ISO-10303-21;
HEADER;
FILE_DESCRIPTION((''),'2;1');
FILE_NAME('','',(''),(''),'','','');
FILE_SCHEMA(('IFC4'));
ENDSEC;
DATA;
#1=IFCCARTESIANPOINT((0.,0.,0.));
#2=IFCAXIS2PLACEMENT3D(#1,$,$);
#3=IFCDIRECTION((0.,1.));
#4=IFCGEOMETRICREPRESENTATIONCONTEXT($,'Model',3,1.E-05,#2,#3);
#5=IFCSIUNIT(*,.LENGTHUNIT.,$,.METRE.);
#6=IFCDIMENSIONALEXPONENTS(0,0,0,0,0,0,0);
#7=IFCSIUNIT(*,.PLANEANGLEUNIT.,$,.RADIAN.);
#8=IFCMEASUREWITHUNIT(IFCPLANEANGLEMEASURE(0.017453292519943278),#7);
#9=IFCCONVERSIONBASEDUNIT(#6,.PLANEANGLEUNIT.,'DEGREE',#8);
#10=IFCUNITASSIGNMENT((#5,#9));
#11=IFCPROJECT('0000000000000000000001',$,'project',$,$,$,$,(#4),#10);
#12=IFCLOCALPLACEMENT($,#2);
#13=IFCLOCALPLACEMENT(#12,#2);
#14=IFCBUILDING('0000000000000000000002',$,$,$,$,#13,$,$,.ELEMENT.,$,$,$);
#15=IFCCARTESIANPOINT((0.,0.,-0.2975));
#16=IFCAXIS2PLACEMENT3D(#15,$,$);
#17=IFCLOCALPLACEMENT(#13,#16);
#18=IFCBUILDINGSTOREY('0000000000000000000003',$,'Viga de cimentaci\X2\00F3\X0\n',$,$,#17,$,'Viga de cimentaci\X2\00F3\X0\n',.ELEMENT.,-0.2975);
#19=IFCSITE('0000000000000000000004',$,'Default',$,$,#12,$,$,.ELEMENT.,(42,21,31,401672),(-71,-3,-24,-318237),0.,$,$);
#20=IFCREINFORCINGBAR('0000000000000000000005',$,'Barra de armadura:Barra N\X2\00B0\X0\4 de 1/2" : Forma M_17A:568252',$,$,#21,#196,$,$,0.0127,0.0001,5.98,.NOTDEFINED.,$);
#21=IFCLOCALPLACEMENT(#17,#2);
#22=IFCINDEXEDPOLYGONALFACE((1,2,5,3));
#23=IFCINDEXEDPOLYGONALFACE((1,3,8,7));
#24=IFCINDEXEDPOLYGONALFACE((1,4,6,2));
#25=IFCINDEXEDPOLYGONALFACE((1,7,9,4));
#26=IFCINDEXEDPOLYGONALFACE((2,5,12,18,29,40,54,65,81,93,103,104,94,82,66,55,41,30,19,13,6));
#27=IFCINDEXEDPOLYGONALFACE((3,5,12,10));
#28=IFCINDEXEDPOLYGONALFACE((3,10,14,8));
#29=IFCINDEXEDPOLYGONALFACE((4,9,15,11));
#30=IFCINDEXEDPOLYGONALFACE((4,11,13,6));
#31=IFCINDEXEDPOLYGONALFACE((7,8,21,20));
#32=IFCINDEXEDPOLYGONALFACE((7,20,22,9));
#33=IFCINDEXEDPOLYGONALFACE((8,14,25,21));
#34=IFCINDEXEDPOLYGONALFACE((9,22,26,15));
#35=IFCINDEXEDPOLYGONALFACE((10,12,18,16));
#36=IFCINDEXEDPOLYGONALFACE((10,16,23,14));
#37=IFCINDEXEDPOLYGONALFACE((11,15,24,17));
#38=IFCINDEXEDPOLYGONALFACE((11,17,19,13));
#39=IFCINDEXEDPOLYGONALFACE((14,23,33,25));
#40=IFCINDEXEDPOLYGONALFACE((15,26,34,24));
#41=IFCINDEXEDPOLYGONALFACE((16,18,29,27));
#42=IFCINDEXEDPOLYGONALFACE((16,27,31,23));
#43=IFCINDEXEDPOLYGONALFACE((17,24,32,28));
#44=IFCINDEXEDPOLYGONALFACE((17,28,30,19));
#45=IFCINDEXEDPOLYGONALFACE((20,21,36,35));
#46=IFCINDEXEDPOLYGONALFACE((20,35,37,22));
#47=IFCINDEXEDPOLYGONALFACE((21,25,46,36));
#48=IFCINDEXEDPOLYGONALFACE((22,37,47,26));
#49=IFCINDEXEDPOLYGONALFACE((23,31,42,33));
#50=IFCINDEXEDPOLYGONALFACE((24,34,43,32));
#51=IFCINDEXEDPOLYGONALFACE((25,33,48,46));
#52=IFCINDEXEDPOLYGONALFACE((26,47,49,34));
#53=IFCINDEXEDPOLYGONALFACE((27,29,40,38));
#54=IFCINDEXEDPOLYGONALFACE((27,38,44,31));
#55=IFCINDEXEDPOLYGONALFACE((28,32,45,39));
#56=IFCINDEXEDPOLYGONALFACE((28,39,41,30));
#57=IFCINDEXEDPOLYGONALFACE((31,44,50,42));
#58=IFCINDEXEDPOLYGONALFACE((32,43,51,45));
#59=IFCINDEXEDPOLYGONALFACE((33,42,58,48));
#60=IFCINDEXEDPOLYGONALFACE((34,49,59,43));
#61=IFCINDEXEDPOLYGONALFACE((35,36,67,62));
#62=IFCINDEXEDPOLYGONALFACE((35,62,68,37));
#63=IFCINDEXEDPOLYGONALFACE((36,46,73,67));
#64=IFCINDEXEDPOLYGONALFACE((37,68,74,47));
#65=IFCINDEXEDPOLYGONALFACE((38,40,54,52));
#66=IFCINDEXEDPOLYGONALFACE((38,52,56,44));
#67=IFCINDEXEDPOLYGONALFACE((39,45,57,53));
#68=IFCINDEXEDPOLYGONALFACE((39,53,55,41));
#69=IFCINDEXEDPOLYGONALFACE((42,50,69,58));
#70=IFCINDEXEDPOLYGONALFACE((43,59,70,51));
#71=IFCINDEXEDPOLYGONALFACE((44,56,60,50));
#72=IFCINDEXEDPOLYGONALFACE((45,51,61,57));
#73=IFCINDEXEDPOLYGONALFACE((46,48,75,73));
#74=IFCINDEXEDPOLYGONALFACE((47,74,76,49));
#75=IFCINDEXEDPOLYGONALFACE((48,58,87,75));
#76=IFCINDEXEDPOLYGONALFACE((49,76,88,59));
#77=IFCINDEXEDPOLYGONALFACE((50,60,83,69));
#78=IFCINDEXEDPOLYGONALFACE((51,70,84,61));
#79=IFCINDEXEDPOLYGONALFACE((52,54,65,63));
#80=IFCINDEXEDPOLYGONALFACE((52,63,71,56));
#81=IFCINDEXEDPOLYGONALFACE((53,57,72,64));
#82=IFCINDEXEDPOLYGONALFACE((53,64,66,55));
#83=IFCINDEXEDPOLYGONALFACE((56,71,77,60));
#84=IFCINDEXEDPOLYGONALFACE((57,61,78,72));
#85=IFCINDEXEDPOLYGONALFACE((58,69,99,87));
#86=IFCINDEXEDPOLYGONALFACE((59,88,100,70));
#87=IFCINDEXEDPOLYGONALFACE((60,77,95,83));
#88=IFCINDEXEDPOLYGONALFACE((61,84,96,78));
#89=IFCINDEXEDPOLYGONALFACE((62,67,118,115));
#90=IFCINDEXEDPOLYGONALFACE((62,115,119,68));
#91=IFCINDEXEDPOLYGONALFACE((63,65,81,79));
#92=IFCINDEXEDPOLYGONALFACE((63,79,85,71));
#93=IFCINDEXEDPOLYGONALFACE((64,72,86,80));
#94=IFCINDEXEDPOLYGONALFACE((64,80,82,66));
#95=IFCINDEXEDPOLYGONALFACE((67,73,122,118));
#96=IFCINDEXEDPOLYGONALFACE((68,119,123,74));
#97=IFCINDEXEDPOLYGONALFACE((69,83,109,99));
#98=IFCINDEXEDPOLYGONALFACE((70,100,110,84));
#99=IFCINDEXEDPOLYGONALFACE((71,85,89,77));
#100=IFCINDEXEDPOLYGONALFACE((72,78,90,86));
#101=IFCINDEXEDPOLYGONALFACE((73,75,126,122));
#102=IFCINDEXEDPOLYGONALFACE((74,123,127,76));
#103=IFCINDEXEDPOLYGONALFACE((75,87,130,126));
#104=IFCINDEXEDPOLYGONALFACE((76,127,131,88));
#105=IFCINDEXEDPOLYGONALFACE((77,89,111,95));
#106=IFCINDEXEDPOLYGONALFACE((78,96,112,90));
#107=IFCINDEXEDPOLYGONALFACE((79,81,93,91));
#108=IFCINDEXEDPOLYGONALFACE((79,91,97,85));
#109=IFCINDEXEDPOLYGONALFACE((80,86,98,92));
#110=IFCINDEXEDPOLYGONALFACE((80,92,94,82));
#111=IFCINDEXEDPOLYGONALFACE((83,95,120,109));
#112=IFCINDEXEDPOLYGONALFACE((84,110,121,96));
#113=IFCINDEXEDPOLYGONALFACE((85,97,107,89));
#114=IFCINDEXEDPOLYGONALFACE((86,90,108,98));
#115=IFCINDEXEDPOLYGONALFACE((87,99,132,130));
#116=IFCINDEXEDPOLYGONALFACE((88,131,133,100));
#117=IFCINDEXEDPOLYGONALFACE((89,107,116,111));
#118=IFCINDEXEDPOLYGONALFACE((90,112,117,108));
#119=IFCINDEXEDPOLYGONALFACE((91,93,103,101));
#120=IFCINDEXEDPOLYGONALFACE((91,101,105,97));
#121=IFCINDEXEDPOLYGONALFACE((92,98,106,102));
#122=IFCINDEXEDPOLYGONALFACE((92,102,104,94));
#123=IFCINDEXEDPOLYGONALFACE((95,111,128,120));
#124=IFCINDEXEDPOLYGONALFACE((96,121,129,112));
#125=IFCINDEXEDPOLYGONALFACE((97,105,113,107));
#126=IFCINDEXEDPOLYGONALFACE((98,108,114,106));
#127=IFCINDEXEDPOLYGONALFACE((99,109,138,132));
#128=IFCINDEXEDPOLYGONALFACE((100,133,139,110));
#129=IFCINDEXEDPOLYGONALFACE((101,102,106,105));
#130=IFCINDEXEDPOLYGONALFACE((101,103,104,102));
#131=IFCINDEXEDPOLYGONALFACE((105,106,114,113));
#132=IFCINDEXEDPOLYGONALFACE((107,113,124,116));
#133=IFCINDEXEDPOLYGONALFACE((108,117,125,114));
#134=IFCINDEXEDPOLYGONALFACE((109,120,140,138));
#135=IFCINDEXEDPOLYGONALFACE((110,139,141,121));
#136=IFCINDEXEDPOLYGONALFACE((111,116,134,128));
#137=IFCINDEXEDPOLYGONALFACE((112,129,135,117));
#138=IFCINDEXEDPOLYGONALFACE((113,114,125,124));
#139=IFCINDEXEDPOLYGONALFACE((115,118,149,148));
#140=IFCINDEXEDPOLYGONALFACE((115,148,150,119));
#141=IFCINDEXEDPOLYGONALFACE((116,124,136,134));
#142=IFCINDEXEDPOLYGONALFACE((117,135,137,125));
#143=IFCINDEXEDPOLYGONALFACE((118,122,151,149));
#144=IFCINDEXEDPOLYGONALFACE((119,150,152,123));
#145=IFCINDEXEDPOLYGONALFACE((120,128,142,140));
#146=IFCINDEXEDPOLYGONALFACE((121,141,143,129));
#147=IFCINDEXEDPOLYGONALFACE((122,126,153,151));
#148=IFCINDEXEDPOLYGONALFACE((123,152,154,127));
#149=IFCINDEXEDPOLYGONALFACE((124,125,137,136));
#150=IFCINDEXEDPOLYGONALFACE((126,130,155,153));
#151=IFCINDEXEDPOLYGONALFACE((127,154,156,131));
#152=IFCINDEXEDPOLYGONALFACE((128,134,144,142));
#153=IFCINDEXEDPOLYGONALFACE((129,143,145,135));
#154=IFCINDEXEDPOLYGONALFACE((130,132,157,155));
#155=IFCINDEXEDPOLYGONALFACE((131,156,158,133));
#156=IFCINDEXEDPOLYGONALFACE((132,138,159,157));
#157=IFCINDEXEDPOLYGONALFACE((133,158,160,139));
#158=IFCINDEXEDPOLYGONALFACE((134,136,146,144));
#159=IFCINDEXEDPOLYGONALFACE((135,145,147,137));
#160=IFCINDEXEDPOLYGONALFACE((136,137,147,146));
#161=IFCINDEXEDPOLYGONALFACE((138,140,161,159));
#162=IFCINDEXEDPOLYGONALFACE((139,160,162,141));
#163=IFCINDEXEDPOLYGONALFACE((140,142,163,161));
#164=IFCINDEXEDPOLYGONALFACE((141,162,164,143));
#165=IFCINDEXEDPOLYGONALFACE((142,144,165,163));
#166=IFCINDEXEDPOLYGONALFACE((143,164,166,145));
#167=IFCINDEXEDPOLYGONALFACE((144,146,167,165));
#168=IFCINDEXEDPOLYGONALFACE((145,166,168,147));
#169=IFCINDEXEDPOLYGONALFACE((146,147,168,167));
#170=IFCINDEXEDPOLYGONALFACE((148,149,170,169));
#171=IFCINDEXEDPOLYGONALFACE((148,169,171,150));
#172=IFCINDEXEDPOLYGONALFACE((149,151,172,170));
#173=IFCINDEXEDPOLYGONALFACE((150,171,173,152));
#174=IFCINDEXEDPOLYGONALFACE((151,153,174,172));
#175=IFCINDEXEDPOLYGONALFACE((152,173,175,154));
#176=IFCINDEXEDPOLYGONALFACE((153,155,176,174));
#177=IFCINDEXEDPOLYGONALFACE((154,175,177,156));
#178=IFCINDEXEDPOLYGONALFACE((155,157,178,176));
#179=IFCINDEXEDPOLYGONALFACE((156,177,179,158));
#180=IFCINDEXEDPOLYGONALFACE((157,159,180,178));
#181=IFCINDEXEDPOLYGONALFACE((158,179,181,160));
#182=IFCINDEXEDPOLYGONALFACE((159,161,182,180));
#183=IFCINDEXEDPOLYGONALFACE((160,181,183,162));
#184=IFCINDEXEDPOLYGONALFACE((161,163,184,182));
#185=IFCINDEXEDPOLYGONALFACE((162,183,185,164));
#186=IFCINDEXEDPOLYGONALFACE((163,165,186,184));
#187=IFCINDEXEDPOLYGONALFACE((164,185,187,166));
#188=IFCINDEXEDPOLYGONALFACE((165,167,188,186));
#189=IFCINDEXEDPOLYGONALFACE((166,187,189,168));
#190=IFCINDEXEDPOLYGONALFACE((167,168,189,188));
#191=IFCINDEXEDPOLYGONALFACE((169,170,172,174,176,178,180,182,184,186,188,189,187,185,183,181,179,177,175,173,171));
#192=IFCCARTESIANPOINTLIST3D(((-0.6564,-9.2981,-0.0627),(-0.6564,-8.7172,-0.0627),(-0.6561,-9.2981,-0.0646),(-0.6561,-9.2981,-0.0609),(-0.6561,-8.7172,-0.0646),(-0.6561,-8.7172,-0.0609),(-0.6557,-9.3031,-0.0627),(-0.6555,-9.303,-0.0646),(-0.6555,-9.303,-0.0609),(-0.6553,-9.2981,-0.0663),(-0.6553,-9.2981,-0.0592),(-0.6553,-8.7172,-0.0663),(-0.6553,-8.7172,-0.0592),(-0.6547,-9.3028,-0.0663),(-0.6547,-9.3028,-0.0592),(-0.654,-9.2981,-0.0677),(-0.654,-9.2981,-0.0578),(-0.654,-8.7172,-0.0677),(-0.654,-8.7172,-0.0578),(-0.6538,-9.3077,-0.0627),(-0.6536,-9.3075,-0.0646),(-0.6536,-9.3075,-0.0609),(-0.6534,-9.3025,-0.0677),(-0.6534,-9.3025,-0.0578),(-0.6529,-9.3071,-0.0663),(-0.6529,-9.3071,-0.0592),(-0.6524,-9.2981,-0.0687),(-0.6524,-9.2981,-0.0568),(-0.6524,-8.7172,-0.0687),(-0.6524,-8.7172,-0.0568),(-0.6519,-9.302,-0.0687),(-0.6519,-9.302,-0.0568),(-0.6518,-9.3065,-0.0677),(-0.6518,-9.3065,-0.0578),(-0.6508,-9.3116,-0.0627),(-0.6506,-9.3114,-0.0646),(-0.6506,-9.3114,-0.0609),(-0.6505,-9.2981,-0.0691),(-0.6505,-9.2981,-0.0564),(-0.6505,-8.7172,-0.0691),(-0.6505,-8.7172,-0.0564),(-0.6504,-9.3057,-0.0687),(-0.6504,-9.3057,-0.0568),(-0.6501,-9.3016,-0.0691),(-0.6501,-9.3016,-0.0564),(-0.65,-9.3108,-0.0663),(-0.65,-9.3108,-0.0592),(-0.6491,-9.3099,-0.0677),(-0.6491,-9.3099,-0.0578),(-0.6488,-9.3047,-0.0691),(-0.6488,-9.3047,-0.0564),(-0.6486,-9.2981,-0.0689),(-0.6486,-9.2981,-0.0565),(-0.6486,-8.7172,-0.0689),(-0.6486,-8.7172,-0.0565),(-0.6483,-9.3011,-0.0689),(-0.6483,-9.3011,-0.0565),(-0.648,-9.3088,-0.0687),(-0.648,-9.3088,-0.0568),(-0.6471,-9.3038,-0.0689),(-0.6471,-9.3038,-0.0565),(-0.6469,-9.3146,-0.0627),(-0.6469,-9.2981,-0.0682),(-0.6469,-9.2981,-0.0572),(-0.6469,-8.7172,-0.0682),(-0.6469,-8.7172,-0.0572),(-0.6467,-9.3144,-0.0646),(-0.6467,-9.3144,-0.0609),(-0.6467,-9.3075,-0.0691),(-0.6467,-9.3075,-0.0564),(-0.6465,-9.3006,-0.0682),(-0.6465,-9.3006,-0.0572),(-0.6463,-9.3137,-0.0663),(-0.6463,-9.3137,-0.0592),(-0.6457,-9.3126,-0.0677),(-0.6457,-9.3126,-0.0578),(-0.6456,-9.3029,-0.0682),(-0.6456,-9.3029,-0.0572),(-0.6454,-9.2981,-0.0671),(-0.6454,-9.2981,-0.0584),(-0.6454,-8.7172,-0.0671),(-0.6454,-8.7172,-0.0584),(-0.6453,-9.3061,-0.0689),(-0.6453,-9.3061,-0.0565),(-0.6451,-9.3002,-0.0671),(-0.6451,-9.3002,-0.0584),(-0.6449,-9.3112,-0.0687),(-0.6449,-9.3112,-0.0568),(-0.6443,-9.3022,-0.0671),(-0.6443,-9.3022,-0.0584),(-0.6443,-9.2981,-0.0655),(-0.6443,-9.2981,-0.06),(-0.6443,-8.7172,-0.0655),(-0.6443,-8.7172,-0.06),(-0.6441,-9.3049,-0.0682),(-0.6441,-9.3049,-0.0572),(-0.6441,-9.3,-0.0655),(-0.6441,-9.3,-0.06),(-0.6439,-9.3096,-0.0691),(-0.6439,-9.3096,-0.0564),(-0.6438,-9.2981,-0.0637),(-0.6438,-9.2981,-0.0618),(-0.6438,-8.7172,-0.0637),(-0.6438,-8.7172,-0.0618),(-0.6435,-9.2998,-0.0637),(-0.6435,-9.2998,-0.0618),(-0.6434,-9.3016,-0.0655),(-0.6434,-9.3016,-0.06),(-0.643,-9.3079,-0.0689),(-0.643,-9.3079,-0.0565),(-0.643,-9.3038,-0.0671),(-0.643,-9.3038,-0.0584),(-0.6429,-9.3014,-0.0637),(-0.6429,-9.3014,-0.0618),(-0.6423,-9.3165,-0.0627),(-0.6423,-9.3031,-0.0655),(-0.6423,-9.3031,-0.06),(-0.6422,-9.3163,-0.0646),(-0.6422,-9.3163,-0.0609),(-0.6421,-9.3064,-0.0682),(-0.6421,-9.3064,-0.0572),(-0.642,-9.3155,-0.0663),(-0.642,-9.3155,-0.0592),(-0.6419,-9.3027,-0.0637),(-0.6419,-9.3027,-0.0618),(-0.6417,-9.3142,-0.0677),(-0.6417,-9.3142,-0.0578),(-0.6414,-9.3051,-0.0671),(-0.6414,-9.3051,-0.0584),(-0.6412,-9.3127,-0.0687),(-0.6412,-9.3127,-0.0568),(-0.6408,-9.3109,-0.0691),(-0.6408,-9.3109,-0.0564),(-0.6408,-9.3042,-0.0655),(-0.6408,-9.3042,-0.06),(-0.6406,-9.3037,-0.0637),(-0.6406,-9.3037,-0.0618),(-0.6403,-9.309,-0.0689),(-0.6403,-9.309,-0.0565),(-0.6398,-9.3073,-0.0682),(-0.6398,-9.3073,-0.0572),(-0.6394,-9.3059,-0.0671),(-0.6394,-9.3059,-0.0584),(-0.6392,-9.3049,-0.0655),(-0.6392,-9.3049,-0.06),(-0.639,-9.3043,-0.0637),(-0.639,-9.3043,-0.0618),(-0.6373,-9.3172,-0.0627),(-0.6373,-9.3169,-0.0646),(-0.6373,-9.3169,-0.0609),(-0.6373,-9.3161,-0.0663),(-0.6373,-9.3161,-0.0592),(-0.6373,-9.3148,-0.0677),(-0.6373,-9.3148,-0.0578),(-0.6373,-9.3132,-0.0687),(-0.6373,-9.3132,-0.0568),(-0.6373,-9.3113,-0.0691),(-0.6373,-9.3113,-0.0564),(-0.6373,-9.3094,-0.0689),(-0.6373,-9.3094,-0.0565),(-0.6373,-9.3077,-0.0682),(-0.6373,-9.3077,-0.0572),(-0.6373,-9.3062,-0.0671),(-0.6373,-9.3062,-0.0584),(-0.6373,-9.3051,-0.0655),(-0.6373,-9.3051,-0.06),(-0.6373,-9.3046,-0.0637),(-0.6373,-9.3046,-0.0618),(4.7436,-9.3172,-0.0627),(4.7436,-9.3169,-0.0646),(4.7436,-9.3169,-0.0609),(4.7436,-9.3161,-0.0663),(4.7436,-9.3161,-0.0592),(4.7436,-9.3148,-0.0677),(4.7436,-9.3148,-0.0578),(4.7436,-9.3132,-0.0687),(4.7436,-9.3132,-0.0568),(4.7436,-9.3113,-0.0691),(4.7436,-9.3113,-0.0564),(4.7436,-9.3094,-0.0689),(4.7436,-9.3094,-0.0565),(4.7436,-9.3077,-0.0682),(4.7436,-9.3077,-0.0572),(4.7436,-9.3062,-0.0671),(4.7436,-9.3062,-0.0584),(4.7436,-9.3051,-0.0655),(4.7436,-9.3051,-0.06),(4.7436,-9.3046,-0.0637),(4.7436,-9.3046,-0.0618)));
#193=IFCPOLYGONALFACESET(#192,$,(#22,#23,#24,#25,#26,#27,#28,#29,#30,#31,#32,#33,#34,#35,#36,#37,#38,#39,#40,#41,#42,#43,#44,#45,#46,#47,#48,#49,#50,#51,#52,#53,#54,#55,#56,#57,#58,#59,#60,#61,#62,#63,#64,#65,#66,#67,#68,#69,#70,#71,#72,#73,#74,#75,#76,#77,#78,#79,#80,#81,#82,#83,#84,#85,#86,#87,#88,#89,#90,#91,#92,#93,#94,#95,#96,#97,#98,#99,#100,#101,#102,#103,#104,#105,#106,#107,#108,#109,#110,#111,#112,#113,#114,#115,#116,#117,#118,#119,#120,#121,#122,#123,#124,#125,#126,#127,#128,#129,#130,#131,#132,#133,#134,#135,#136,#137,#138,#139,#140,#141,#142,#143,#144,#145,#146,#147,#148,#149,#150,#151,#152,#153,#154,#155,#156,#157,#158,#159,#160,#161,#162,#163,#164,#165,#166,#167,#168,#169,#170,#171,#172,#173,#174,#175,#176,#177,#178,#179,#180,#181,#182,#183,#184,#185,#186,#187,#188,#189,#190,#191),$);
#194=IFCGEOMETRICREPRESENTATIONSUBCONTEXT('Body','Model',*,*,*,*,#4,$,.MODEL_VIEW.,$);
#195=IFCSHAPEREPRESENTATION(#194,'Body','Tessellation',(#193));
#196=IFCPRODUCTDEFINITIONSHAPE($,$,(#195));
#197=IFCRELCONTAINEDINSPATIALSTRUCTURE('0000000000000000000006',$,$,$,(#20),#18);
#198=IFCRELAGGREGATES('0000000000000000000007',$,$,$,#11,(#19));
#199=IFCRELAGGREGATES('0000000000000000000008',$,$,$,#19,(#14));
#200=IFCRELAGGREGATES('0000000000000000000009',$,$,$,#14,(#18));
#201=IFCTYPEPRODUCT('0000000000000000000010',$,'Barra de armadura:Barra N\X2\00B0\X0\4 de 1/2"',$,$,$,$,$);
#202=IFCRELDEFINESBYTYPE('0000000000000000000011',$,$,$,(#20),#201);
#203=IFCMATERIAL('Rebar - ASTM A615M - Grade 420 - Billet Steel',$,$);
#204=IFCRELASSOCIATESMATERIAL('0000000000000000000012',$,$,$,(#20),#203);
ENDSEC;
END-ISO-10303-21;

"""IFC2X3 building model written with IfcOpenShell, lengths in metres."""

from ifc_helpers import new_model, entity, si_unit, converted_unit, direction, frame, origin, place, context, subcontext, project, spatial, material, type_object, element, save


model = new_model("IFC2X3")

# Units and contexts
model_context = context("Model", 3, precision=1e-05, world=origin(), true_north=direction((0.0, 1.0)))
body_context = subcontext(model_context, "Body", "Model", "MODEL_VIEW")
ifc_project = project(units=[si_unit("LENGTHUNIT", "METRE"), converted_unit("PLANEANGLEUNIT", "DEGREE", entity("IfcPlaneAngleMeasure", 0.017453292519943278), si_unit("PLANEANGLEUNIT", "RADIAN"), dimensions=[0, 0, 0, 0, 0, 0, 0])], contexts=[model_context])

# Site, building, storey
site_placement = place(None, origin())
site = spatial("IfcSite", under=ifc_project, at=site_placement, Name="Default", CompositionType="ELEMENT", RefLatitude=(42, 21, 31, 401672), RefLongitude=(-71, -3, -24, -318237), RefElevation=0.0)
building_placement = place(site_placement, origin())
building = spatial("IfcBuilding", under=site, at=building_placement, CompositionType="ELEMENT")
storey_placement = place(building_placement, frame((0.0, 0.0, -0.2975)))
storey = spatial("IfcBuildingStorey", under=building, at=storey_placement, Name="Viga de cimentación", LongName="Viga de cimentación", CompositionType="ELEMENT", Elevation=-0.2975)

# Reinforcing bar
ifc_material = material(Name="Rebar - ASTM A615M - Grade 420 - Billet Steel")
type_product_1 = type_object("IfcTypeProduct", Name="Barra de armadura:Barra N°4 de 1/2\"")
reinforcing_bar_1_placement = place(storey_placement, origin())
element("IfcReinforcingBar", 1, at=reinforcing_bar_1_placement, inside=storey, type_object=type_product_1, material=ifc_material, Name="Barra de armadura:Barra N°4 de 1/2\" : Forma M_17A:568252", BarLength=5.98, BarRole="NOTDEFINED", CrossSectionArea=0.0001, NominalDiameter=0.0127, context=body_context, shape_type="AdvancedSweptSolid", body=[
    entity("IfcSweptDiskSolid", entity("IfcCompositeCurve", [entity("IfcCompositeCurveSegment", "CONTINUOUS", True, entity("IfcPolyline", [entity("IfcCartesianPoint", [-0.65, -8.7172, -0.0627]), entity("IfcCartesianPoint", [-0.65, -9.2981, -0.0627])])), entity("IfcCompositeCurveSegment", "CONTINUOUS", True, entity("IfcTrimmedCurve", entity("IfcCircle", entity("IfcAxis2Placement3D", entity("IfcCartesianPoint", [-0.6373, -9.2981, -0.0627]), entity("IfcDirection", [0.0, 0.0, 1.0]), entity("IfcDirection", [0.0, -1.0, 0.0])), 0.0127), [entity("IfcParameterValue", 270.0)], [entity("IfcParameterValue", 360.0)], True, "PARAMETER")), entity("IfcCompositeCurveSegment", "CONTINUOUS", True, entity("IfcPolyline", [entity("IfcCartesianPoint", [-0.6373, -9.3108, -0.0627]), entity("IfcCartesianPoint", [4.7436, -9.3108, -0.0627])]))], False), 0.0063, None, 0.0, 92.0),
])

save(model, "model.ifc")
